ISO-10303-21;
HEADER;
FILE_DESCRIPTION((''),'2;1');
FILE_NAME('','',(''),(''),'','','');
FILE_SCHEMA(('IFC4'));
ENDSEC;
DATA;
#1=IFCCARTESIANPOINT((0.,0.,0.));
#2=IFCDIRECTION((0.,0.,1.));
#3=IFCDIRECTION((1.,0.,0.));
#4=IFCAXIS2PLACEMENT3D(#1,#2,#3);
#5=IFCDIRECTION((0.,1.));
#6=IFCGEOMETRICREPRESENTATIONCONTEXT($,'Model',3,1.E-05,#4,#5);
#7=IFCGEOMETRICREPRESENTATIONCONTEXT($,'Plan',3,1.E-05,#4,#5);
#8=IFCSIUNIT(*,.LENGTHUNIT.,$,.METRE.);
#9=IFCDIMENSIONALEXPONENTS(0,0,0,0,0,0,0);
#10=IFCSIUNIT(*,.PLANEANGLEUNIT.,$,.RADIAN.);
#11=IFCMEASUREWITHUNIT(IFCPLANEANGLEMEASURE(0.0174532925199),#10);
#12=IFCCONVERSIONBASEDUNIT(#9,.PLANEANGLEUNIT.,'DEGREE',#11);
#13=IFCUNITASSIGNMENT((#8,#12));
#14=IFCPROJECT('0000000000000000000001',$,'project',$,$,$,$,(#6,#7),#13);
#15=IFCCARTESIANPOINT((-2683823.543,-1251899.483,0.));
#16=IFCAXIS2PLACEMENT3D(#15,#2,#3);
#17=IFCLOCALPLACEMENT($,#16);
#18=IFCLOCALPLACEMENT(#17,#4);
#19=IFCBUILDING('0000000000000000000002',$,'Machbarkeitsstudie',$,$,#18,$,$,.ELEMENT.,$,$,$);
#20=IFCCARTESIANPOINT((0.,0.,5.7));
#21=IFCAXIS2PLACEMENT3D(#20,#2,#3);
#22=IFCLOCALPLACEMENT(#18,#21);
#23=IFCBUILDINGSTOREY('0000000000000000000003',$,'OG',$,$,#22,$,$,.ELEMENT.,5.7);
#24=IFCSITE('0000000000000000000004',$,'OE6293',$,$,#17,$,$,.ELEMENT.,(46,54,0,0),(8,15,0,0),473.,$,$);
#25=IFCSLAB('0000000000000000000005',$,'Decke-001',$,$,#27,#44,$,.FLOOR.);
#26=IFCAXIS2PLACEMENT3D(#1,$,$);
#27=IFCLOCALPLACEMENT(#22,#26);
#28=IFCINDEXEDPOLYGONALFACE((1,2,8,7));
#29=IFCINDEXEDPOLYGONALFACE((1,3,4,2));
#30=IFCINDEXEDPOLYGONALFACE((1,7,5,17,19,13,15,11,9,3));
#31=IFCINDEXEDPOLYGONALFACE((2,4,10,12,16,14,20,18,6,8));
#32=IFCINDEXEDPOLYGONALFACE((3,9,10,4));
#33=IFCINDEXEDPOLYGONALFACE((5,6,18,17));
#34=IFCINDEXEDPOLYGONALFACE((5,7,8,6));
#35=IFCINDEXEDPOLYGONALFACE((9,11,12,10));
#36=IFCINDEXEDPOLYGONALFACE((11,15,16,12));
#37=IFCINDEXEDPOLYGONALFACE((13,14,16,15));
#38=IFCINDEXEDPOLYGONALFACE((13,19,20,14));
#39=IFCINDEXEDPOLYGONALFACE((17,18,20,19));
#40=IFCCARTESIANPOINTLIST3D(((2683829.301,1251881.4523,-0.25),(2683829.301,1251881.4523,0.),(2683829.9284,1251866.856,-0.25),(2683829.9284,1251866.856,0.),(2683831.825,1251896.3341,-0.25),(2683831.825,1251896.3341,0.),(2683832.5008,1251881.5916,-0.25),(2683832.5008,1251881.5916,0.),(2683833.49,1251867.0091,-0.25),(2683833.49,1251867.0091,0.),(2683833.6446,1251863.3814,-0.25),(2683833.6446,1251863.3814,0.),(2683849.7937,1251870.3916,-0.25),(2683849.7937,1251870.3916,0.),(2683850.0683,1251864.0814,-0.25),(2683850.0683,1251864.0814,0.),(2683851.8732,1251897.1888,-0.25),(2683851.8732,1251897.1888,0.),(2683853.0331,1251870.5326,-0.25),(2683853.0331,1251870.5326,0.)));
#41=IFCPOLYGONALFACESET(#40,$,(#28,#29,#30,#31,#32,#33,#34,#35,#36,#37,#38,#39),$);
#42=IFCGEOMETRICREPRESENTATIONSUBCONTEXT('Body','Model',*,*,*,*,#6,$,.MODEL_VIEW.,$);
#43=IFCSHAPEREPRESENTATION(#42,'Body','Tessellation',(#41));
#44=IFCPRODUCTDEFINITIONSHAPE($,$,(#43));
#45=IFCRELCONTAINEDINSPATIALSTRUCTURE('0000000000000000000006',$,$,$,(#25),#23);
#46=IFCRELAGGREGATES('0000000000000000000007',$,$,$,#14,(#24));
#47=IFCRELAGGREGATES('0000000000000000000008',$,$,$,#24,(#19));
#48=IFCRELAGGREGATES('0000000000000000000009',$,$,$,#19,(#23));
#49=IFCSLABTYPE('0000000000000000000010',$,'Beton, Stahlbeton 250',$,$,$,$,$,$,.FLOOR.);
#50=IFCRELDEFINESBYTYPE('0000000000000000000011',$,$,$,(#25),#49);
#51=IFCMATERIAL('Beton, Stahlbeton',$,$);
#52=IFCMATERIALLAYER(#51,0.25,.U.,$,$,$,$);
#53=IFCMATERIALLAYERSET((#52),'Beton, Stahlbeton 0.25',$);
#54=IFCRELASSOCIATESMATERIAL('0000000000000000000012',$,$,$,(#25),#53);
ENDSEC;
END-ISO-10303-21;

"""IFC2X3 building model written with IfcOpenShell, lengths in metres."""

from ifc_helpers import new_model, entity, si_unit, converted_unit, direction, frame, origin_with_axes, place, context, subcontext, project, spatial, polyline, outline, extrude, material, layer, layer_set, layer_usage, type_object, element, save


model = new_model("IFC2X3")

# Units and contexts
model_context = context("Model", 3, precision=1e-05, world=origin_with_axes(), true_north=direction((0.0, 1.0)))
plan_context = context("Plan", 3, precision=1e-05, world=origin_with_axes(), true_north=direction((0.0, 1.0)))
body_context = subcontext(model_context, "Body", "Model", "MODEL_VIEW")
ifc_project = project(units=[si_unit("LENGTHUNIT", "METRE"), converted_unit("PLANEANGLEUNIT", "DEGREE", entity("IfcPlaneAngleMeasure", 0.0174532925199), si_unit("PLANEANGLEUNIT", "RADIAN"), dimensions=[0, 0, 0, 0, 0, 0, 0])], contexts=[model_context, plan_context])

# Site, building, storey
site_placement = place(None, frame((-2683823.543, -1251899.483, 0.0), z_axis=(0.0, 0.0, 1.0), x_axis=(1.0, 0.0, 0.0)))
site = spatial("IfcSite", under=ifc_project, at=site_placement, Name="OE6293", CompositionType="ELEMENT", RefLatitude=(46, 54, 0, 0), RefLongitude=(8, 15, 0, 0), RefElevation=473.0)
building_placement = place(site_placement, origin_with_axes())
building = spatial("IfcBuilding", under=site, at=building_placement, Name="Machbarkeitsstudie", CompositionType="ELEMENT")
storey_placement = place(building_placement, frame((0.0, 0.0, 5.7), z_axis=(0.0, 0.0, 1.0), x_axis=(1.0, 0.0, 0.0)))
storey = spatial("IfcBuildingStorey", under=building, at=storey_placement, Name="OG", CompositionType="ELEMENT", Elevation=5.7)

# Slab
ifc_material = material(Name="Beton, Stahlbeton")
ifc_layer = layer(ifc_material, 0.25, ventilated="UNKNOWN")
ifc_layer_set = layer_set([ifc_layer], Name="Beton, Stahlbeton 0.25")
ifc_layer_usage = layer_usage(ifc_layer_set, "AXIS3", "NEGATIVE", 0.25)
slab_type = type_object("IfcSlabType", Name="Beton, Stahlbeton 250", PredefinedType="FLOOR")
slab_placement = place(storey_placement, frame((2683832.5008, 1251881.5916, 0.0), z_axis=(0.0, 0.0, 1.0), x_axis=(1.0, 0.0, 0.0)))
element("IfcSlab", 1, at=slab_placement, inside=storey, type_object=slab_type, material=ifc_layer_usage, Name="Decke-001", PredefinedType="FLOOR", context=body_context, shape_type="SweptSolid", body=[
    extrude(outline(polyline([(0.0, 0.0), (-3.1998, -0.1392), (-2.5724, -14.7356), (0.9892, -14.5825), (1.1438, -18.2102), (17.5674, -17.5102), (17.2928, -11.2), (20.5323, -11.059), (19.3724, 15.5972), (-0.6758, 14.7426), (0.0, 0.0)])), frame((0.0, 0.0, -0.25), z_axis=(0.0, 0.0, 1.0), x_axis=(1.0, 0.0, 0.0)), (0.0, 0.0, 1.0), 0.25),
])

save(model, "model.ifc")
